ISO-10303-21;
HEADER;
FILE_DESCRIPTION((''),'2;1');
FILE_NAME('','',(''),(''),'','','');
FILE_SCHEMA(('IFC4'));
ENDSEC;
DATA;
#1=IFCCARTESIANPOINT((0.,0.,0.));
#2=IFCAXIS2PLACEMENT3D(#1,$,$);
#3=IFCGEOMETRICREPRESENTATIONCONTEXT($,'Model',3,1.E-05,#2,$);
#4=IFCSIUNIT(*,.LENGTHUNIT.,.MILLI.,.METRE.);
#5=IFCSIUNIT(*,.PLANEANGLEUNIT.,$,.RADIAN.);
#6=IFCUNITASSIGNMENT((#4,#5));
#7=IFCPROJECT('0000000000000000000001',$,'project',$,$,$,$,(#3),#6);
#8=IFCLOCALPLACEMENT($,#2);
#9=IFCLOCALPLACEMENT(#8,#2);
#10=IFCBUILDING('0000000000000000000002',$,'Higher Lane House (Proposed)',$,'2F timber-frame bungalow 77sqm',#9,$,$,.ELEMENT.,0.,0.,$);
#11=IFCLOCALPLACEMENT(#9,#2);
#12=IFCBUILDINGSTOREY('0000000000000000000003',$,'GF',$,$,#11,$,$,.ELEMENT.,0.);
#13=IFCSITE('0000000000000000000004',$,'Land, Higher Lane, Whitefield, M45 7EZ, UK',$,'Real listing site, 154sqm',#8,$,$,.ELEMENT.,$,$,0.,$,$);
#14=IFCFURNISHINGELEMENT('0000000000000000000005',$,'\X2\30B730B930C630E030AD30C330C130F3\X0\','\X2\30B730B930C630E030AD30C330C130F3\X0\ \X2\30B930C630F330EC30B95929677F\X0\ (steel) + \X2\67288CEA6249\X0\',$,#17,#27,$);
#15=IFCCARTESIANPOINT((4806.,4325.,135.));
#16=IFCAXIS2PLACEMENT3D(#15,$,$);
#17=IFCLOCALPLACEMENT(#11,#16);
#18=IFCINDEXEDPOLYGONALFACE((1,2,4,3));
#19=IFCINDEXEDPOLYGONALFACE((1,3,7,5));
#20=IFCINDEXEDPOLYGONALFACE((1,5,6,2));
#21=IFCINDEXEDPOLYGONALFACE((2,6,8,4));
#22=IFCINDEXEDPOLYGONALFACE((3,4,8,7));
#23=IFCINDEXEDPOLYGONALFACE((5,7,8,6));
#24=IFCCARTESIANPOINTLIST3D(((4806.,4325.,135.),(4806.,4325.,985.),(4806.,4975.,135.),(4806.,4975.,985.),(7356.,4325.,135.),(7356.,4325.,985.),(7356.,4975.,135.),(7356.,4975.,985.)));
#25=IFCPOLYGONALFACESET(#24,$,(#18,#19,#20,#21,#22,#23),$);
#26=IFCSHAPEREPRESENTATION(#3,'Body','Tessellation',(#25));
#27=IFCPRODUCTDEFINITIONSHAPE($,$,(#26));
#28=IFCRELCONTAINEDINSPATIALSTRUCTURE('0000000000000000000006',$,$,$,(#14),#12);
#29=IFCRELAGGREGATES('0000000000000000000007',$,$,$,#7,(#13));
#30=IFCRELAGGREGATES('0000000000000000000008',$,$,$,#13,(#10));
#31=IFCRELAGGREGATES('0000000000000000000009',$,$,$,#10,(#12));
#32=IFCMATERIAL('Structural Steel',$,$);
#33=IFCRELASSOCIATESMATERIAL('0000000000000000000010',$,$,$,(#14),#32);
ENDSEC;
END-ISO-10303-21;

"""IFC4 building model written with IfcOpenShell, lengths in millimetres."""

from ifc_helpers import new_model, si_unit, frame, frame_2d, origin, place, context, project, spatial, rectangle, extrude, material, element, save


model = new_model("IFC4")

# Units and contexts
model_context = context("Model", 3, precision=1e-05, world=origin())
ifc_project = project(units=[si_unit("LENGTHUNIT", "METRE", prefix="MILLI"), si_unit("PLANEANGLEUNIT", "RADIAN")], contexts=[model_context])

# Site, building, storey
site_placement = place(None, origin())
site = spatial("IfcSite", under=ifc_project, at=site_placement, Name="Land, Higher Lane, Whitefield, M45 7EZ, UK", ObjectType="Real listing site, 154sqm", CompositionType="ELEMENT", RefElevation=0.0)
building_placement = place(site_placement, origin())
building = spatial("IfcBuilding", under=site, at=building_placement, Name="Higher Lane House (Proposed)", ObjectType="2F timber-frame bungalow 77sqm", CompositionType="ELEMENT", ElevationOfRefHeight=0.0, ElevationOfTerrain=0.0)
storey_placement = place(building_placement, origin())
storey = spatial("IfcBuildingStorey", under=building, at=storey_placement, Name="GF", CompositionType="ELEMENT", Elevation=0.0)

# Furnishing element
ifc_material_1 = material(Name="Structural Steel")
furnishing_1_placement = place(storey_placement, frame((4806.0, 4325.0, 135.0)))
element("IfcFurnishingElement", 1, at=furnishing_1_placement, inside=storey, material=ifc_material_1, Name="システムキッチン", Description="システムキッチン ステンレス天板 (steel) + 木質扉", context=model_context, shape_type="SweptSolid", body=[
    extrude(rectangle(XDim=2550.0, YDim=650.0, at=frame_2d((1275.0, 325.0))), frame((4806.0, 4325.0, 135.0)), (0.0, 0.0, 1.0), 850.0),
])

save(model, "model.ifc")
